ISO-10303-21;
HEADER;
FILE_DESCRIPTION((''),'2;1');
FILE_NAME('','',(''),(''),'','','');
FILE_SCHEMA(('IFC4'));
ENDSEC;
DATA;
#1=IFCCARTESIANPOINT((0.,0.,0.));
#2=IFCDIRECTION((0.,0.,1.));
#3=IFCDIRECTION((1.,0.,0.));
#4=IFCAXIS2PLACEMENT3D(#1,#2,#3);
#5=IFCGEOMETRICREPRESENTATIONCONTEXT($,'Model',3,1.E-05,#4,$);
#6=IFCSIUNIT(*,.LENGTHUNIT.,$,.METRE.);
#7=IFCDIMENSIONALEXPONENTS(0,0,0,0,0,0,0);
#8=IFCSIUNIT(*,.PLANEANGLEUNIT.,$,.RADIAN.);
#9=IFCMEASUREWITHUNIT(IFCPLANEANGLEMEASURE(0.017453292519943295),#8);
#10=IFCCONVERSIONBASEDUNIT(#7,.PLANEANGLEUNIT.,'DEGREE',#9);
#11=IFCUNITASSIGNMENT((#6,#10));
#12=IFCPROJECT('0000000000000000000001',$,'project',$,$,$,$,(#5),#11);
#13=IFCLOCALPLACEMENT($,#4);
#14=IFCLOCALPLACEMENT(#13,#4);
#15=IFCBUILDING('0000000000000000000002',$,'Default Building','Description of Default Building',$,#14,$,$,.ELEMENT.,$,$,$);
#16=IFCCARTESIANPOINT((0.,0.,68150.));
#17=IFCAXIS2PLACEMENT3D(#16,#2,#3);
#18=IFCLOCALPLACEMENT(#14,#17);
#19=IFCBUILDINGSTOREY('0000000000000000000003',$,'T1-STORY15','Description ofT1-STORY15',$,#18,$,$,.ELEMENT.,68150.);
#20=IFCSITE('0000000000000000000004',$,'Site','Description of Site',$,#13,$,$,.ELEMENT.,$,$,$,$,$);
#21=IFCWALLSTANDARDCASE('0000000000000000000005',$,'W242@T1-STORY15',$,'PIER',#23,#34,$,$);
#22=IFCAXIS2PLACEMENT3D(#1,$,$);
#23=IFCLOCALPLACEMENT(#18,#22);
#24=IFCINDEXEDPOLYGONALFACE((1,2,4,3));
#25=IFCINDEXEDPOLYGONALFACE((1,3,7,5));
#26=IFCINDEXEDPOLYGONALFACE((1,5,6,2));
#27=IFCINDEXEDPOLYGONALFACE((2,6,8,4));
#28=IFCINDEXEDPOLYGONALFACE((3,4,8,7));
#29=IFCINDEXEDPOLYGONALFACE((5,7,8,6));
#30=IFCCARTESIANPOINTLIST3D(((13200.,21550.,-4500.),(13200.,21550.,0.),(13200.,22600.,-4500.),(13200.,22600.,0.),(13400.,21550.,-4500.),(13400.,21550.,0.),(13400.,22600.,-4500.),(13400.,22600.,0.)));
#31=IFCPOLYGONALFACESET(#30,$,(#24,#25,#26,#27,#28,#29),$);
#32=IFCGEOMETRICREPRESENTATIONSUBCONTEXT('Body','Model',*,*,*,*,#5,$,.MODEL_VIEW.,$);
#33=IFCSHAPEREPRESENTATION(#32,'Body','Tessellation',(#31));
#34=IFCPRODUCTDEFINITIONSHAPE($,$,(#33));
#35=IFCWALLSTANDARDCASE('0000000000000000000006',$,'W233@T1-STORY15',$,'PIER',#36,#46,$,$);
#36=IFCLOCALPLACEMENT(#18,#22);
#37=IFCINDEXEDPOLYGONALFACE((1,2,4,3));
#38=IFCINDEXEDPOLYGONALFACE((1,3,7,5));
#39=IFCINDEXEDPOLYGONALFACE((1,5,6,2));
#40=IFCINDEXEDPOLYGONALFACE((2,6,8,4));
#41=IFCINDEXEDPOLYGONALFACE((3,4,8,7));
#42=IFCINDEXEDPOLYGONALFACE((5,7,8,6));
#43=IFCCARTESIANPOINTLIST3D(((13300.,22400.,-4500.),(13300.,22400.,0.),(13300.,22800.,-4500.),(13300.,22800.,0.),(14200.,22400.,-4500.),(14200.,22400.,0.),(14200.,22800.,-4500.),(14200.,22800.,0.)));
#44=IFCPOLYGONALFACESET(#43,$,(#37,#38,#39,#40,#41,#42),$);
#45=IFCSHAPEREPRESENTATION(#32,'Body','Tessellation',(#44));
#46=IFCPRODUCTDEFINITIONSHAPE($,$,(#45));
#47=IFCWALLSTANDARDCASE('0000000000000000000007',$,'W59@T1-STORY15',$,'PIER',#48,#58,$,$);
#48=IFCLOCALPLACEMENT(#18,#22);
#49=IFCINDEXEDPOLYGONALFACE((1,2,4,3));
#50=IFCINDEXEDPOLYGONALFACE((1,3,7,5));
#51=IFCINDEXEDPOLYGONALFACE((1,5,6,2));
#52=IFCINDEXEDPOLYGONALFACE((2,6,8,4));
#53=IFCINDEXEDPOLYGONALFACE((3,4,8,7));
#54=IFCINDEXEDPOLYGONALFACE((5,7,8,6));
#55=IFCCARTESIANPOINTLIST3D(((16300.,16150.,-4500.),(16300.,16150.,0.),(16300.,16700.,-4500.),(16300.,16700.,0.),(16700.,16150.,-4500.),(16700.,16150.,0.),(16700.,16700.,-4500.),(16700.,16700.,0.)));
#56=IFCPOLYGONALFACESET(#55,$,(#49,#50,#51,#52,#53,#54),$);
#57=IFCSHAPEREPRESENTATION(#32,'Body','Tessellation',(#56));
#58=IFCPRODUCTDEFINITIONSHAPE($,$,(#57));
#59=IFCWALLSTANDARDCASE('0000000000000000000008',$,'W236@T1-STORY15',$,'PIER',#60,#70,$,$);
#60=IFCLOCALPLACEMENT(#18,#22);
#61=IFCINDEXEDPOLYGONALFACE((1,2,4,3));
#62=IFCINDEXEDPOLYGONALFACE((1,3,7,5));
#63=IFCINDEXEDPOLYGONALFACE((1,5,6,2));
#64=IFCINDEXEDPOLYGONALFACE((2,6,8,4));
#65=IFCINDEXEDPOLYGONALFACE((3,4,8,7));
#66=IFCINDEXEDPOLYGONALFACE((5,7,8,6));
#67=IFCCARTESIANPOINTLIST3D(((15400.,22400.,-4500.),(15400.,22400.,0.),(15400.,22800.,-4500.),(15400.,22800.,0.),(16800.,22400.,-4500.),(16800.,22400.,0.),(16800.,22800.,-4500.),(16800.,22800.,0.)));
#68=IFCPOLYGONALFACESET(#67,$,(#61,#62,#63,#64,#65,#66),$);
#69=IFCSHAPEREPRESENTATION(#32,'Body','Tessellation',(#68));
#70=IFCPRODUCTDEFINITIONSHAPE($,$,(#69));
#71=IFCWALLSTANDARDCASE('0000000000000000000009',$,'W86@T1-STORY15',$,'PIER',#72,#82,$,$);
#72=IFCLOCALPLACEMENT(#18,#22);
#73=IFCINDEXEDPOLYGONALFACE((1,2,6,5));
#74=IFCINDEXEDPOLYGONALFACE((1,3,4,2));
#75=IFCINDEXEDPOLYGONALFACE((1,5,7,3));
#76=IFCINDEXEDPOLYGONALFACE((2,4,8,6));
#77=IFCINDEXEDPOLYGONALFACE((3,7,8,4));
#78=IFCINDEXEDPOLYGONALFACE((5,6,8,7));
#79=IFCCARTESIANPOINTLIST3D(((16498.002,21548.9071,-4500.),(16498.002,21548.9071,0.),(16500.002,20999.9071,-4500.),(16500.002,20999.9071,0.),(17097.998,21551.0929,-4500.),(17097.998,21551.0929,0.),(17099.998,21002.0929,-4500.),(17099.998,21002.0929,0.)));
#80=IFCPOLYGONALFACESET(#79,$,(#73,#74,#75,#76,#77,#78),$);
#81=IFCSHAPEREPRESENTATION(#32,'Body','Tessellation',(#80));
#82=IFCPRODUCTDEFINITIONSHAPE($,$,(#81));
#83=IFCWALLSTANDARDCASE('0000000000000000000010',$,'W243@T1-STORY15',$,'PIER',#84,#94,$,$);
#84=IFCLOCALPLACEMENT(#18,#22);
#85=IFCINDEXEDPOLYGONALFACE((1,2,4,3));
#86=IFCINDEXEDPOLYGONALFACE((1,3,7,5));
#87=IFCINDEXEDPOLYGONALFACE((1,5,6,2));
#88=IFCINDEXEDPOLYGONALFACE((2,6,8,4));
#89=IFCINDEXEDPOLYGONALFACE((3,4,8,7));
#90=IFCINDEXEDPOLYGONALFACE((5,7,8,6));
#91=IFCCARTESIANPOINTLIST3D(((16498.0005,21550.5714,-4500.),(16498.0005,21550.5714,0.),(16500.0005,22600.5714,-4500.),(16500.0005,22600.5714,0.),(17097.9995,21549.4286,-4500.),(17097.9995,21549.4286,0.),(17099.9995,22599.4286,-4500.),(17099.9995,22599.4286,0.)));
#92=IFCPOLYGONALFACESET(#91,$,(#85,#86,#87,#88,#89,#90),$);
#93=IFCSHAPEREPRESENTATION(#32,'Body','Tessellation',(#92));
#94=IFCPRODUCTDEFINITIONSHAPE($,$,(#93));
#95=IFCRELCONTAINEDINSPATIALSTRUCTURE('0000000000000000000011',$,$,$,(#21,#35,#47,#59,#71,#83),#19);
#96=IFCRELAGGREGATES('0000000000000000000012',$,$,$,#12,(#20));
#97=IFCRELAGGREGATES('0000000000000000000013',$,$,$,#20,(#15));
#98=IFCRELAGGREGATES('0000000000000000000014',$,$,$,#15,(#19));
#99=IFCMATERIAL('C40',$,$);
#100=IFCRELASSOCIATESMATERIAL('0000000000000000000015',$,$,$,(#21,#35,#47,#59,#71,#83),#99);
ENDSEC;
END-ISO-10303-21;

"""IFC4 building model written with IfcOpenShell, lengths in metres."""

from ifc_helpers import new_model, entity, si_unit, converted_unit, frame, origin_with_axes, place, context, subcontext, project, spatial, indexed_curve, outline, extrude, material, element, save


model = new_model("IFC4")

# Units and contexts
model_context = context("Model", 3, precision=1e-05, world=origin_with_axes())
body_context = subcontext(model_context, "Body", "Model", "MODEL_VIEW")
ifc_project = project(units=[si_unit("LENGTHUNIT", "METRE"), converted_unit("PLANEANGLEUNIT", "DEGREE", entity("IfcPlaneAngleMeasure", 0.017453292519943295), si_unit("PLANEANGLEUNIT", "RADIAN"), dimensions=[0, 0, 0, 0, 0, 0, 0])], contexts=[model_context])

# Site, building, storey
site_placement = place(None, origin_with_axes())
site = spatial("IfcSite", under=ifc_project, at=site_placement, Name="Site", Description="Description of Site", CompositionType="ELEMENT")
building_placement = place(site_placement, origin_with_axes())
building = spatial("IfcBuilding", under=site, at=building_placement, Name="Default Building", Description="Description of Default Building", CompositionType="ELEMENT")
storey_placement = place(building_placement, frame((0.0, 0.0, 68150.0), z_axis=(0.0, 0.0, 1.0), x_axis=(1.0, 0.0, 0.0)))
storey = spatial("IfcBuildingStorey", under=building, at=storey_placement, Name="T1-STORY15", Description="Description ofT1-STORY15", CompositionType="ELEMENT", Elevation=68150.0)

# Walls
ifc_material_1 = material(Name="C40")
wall_1_placement = place(storey_placement, frame((13300.0, 21550.0, -4500.0), z_axis=(0.0, 0.0, 1.0), x_axis=(0.0, 1.0, 0.0)))
element("IfcWallStandardCase", 1, at=wall_1_placement, inside=storey, material=ifc_material_1, Name="W242@T1-STORY15", ObjectType="PIER", context=body_context, shape_type="SweptSolid", body=[
    extrude(outline(indexed_curve([(0.0, -100.0), (0.0, 100.0), (1050.0, 100.0), (1050.0, -100.0), (0.0, -100.0)], self_intersect=False)), origin_with_axes(), (0.0, 0.0, 1.0), 4500.0),
])
wall_2_placement = place(storey_placement, frame((13300.0, 22600.0, -4500.0), z_axis=(0.0, 0.0, 1.0), x_axis=(1.0, 0.0, 0.0)))
element("IfcWallStandardCase", 2, at=wall_2_placement, inside=storey, material=ifc_material_1, Name="W233@T1-STORY15", ObjectType="PIER", context=body_context, shape_type="SweptSolid", body=[
    extrude(outline(indexed_curve([(0.0, -200.0), (0.0, 200.0), (900.0, 200.0), (900.0, -200.0), (0.0, -200.0)], self_intersect=False)), origin_with_axes(), (0.0, 0.0, 1.0), 4500.0),
])
wall_3_placement = place(storey_placement, frame((16500.0, 16150.0, -4500.0), z_axis=(0.0, 0.0, 1.0), x_axis=(0.0, 1.0, 0.0)))
element("IfcWallStandardCase", 3, at=wall_3_placement, inside=storey, material=ifc_material_1, Name="W59@T1-STORY15", ObjectType="PIER", context=body_context, shape_type="SweptSolid", body=[
    extrude(outline(indexed_curve([(0.0, -200.0), (0.0, 200.0), (550.0, 200.0), (550.0, -200.0), (0.0, -200.0)], self_intersect=False)), origin_with_axes(), (0.0, 0.0, 1.0), 4500.0),
])
wall_4_placement = place(storey_placement, frame((15400.0, 22600.0, -4500.0), z_axis=(0.0, 0.0, 1.0), x_axis=(1.0, 0.0, 0.0)))
element("IfcWallStandardCase", 4, at=wall_4_placement, inside=storey, material=ifc_material_1, Name="W236@T1-STORY15", ObjectType="PIER", context=body_context, shape_type="SweptSolid", body=[
    extrude(outline(indexed_curve([(0.0, -200.0), (0.0, 200.0), (1400.0, 200.0), (1400.0, -200.0), (0.0, -200.0)], self_intersect=False)), origin_with_axes(), (0.0, 0.0, 1.0), 4500.0),
])
wall_5_placement = place(storey_placement, frame((16800.0, 21001.0, -4500.0), z_axis=(0.0, 0.0, 1.0), x_axis=(-0.003643, 0.999993, 0.0)))
element("IfcWallStandardCase", 5, at=wall_5_placement, inside=storey, material=ifc_material_1, Name="W86@T1-STORY15", ObjectType="PIER", context=body_context, shape_type="SweptSolid", body=[
    extrude(outline(indexed_curve([(0.0, -300.0), (0.0, 300.0), (549.0036, 300.0), (549.0036, -300.0), (0.0, -300.0)], self_intersect=False)), origin_with_axes(), (0.0, 0.0, 1.0), 4500.0),
])
wall_6_placement = place(storey_placement, frame((16798.0, 21550.0, -4500.0), z_axis=(0.0, 0.0, 1.0), x_axis=(0.001905, 0.999998, 0.0)))
element("IfcWallStandardCase", 6, at=wall_6_placement, inside=storey, material=ifc_material_1, Name="W243@T1-STORY15", ObjectType="PIER", context=body_context, shape_type="SweptSolid", body=[
    extrude(outline(indexed_curve([(0.0, -300.0), (0.0, 300.0), (1050.0019, 300.0), (1050.0019, -300.0), (0.0, -300.0)], self_intersect=False)), origin_with_axes(), (0.0, 0.0, 1.0), 4500.0),
])

save(model, "model.ifc")
